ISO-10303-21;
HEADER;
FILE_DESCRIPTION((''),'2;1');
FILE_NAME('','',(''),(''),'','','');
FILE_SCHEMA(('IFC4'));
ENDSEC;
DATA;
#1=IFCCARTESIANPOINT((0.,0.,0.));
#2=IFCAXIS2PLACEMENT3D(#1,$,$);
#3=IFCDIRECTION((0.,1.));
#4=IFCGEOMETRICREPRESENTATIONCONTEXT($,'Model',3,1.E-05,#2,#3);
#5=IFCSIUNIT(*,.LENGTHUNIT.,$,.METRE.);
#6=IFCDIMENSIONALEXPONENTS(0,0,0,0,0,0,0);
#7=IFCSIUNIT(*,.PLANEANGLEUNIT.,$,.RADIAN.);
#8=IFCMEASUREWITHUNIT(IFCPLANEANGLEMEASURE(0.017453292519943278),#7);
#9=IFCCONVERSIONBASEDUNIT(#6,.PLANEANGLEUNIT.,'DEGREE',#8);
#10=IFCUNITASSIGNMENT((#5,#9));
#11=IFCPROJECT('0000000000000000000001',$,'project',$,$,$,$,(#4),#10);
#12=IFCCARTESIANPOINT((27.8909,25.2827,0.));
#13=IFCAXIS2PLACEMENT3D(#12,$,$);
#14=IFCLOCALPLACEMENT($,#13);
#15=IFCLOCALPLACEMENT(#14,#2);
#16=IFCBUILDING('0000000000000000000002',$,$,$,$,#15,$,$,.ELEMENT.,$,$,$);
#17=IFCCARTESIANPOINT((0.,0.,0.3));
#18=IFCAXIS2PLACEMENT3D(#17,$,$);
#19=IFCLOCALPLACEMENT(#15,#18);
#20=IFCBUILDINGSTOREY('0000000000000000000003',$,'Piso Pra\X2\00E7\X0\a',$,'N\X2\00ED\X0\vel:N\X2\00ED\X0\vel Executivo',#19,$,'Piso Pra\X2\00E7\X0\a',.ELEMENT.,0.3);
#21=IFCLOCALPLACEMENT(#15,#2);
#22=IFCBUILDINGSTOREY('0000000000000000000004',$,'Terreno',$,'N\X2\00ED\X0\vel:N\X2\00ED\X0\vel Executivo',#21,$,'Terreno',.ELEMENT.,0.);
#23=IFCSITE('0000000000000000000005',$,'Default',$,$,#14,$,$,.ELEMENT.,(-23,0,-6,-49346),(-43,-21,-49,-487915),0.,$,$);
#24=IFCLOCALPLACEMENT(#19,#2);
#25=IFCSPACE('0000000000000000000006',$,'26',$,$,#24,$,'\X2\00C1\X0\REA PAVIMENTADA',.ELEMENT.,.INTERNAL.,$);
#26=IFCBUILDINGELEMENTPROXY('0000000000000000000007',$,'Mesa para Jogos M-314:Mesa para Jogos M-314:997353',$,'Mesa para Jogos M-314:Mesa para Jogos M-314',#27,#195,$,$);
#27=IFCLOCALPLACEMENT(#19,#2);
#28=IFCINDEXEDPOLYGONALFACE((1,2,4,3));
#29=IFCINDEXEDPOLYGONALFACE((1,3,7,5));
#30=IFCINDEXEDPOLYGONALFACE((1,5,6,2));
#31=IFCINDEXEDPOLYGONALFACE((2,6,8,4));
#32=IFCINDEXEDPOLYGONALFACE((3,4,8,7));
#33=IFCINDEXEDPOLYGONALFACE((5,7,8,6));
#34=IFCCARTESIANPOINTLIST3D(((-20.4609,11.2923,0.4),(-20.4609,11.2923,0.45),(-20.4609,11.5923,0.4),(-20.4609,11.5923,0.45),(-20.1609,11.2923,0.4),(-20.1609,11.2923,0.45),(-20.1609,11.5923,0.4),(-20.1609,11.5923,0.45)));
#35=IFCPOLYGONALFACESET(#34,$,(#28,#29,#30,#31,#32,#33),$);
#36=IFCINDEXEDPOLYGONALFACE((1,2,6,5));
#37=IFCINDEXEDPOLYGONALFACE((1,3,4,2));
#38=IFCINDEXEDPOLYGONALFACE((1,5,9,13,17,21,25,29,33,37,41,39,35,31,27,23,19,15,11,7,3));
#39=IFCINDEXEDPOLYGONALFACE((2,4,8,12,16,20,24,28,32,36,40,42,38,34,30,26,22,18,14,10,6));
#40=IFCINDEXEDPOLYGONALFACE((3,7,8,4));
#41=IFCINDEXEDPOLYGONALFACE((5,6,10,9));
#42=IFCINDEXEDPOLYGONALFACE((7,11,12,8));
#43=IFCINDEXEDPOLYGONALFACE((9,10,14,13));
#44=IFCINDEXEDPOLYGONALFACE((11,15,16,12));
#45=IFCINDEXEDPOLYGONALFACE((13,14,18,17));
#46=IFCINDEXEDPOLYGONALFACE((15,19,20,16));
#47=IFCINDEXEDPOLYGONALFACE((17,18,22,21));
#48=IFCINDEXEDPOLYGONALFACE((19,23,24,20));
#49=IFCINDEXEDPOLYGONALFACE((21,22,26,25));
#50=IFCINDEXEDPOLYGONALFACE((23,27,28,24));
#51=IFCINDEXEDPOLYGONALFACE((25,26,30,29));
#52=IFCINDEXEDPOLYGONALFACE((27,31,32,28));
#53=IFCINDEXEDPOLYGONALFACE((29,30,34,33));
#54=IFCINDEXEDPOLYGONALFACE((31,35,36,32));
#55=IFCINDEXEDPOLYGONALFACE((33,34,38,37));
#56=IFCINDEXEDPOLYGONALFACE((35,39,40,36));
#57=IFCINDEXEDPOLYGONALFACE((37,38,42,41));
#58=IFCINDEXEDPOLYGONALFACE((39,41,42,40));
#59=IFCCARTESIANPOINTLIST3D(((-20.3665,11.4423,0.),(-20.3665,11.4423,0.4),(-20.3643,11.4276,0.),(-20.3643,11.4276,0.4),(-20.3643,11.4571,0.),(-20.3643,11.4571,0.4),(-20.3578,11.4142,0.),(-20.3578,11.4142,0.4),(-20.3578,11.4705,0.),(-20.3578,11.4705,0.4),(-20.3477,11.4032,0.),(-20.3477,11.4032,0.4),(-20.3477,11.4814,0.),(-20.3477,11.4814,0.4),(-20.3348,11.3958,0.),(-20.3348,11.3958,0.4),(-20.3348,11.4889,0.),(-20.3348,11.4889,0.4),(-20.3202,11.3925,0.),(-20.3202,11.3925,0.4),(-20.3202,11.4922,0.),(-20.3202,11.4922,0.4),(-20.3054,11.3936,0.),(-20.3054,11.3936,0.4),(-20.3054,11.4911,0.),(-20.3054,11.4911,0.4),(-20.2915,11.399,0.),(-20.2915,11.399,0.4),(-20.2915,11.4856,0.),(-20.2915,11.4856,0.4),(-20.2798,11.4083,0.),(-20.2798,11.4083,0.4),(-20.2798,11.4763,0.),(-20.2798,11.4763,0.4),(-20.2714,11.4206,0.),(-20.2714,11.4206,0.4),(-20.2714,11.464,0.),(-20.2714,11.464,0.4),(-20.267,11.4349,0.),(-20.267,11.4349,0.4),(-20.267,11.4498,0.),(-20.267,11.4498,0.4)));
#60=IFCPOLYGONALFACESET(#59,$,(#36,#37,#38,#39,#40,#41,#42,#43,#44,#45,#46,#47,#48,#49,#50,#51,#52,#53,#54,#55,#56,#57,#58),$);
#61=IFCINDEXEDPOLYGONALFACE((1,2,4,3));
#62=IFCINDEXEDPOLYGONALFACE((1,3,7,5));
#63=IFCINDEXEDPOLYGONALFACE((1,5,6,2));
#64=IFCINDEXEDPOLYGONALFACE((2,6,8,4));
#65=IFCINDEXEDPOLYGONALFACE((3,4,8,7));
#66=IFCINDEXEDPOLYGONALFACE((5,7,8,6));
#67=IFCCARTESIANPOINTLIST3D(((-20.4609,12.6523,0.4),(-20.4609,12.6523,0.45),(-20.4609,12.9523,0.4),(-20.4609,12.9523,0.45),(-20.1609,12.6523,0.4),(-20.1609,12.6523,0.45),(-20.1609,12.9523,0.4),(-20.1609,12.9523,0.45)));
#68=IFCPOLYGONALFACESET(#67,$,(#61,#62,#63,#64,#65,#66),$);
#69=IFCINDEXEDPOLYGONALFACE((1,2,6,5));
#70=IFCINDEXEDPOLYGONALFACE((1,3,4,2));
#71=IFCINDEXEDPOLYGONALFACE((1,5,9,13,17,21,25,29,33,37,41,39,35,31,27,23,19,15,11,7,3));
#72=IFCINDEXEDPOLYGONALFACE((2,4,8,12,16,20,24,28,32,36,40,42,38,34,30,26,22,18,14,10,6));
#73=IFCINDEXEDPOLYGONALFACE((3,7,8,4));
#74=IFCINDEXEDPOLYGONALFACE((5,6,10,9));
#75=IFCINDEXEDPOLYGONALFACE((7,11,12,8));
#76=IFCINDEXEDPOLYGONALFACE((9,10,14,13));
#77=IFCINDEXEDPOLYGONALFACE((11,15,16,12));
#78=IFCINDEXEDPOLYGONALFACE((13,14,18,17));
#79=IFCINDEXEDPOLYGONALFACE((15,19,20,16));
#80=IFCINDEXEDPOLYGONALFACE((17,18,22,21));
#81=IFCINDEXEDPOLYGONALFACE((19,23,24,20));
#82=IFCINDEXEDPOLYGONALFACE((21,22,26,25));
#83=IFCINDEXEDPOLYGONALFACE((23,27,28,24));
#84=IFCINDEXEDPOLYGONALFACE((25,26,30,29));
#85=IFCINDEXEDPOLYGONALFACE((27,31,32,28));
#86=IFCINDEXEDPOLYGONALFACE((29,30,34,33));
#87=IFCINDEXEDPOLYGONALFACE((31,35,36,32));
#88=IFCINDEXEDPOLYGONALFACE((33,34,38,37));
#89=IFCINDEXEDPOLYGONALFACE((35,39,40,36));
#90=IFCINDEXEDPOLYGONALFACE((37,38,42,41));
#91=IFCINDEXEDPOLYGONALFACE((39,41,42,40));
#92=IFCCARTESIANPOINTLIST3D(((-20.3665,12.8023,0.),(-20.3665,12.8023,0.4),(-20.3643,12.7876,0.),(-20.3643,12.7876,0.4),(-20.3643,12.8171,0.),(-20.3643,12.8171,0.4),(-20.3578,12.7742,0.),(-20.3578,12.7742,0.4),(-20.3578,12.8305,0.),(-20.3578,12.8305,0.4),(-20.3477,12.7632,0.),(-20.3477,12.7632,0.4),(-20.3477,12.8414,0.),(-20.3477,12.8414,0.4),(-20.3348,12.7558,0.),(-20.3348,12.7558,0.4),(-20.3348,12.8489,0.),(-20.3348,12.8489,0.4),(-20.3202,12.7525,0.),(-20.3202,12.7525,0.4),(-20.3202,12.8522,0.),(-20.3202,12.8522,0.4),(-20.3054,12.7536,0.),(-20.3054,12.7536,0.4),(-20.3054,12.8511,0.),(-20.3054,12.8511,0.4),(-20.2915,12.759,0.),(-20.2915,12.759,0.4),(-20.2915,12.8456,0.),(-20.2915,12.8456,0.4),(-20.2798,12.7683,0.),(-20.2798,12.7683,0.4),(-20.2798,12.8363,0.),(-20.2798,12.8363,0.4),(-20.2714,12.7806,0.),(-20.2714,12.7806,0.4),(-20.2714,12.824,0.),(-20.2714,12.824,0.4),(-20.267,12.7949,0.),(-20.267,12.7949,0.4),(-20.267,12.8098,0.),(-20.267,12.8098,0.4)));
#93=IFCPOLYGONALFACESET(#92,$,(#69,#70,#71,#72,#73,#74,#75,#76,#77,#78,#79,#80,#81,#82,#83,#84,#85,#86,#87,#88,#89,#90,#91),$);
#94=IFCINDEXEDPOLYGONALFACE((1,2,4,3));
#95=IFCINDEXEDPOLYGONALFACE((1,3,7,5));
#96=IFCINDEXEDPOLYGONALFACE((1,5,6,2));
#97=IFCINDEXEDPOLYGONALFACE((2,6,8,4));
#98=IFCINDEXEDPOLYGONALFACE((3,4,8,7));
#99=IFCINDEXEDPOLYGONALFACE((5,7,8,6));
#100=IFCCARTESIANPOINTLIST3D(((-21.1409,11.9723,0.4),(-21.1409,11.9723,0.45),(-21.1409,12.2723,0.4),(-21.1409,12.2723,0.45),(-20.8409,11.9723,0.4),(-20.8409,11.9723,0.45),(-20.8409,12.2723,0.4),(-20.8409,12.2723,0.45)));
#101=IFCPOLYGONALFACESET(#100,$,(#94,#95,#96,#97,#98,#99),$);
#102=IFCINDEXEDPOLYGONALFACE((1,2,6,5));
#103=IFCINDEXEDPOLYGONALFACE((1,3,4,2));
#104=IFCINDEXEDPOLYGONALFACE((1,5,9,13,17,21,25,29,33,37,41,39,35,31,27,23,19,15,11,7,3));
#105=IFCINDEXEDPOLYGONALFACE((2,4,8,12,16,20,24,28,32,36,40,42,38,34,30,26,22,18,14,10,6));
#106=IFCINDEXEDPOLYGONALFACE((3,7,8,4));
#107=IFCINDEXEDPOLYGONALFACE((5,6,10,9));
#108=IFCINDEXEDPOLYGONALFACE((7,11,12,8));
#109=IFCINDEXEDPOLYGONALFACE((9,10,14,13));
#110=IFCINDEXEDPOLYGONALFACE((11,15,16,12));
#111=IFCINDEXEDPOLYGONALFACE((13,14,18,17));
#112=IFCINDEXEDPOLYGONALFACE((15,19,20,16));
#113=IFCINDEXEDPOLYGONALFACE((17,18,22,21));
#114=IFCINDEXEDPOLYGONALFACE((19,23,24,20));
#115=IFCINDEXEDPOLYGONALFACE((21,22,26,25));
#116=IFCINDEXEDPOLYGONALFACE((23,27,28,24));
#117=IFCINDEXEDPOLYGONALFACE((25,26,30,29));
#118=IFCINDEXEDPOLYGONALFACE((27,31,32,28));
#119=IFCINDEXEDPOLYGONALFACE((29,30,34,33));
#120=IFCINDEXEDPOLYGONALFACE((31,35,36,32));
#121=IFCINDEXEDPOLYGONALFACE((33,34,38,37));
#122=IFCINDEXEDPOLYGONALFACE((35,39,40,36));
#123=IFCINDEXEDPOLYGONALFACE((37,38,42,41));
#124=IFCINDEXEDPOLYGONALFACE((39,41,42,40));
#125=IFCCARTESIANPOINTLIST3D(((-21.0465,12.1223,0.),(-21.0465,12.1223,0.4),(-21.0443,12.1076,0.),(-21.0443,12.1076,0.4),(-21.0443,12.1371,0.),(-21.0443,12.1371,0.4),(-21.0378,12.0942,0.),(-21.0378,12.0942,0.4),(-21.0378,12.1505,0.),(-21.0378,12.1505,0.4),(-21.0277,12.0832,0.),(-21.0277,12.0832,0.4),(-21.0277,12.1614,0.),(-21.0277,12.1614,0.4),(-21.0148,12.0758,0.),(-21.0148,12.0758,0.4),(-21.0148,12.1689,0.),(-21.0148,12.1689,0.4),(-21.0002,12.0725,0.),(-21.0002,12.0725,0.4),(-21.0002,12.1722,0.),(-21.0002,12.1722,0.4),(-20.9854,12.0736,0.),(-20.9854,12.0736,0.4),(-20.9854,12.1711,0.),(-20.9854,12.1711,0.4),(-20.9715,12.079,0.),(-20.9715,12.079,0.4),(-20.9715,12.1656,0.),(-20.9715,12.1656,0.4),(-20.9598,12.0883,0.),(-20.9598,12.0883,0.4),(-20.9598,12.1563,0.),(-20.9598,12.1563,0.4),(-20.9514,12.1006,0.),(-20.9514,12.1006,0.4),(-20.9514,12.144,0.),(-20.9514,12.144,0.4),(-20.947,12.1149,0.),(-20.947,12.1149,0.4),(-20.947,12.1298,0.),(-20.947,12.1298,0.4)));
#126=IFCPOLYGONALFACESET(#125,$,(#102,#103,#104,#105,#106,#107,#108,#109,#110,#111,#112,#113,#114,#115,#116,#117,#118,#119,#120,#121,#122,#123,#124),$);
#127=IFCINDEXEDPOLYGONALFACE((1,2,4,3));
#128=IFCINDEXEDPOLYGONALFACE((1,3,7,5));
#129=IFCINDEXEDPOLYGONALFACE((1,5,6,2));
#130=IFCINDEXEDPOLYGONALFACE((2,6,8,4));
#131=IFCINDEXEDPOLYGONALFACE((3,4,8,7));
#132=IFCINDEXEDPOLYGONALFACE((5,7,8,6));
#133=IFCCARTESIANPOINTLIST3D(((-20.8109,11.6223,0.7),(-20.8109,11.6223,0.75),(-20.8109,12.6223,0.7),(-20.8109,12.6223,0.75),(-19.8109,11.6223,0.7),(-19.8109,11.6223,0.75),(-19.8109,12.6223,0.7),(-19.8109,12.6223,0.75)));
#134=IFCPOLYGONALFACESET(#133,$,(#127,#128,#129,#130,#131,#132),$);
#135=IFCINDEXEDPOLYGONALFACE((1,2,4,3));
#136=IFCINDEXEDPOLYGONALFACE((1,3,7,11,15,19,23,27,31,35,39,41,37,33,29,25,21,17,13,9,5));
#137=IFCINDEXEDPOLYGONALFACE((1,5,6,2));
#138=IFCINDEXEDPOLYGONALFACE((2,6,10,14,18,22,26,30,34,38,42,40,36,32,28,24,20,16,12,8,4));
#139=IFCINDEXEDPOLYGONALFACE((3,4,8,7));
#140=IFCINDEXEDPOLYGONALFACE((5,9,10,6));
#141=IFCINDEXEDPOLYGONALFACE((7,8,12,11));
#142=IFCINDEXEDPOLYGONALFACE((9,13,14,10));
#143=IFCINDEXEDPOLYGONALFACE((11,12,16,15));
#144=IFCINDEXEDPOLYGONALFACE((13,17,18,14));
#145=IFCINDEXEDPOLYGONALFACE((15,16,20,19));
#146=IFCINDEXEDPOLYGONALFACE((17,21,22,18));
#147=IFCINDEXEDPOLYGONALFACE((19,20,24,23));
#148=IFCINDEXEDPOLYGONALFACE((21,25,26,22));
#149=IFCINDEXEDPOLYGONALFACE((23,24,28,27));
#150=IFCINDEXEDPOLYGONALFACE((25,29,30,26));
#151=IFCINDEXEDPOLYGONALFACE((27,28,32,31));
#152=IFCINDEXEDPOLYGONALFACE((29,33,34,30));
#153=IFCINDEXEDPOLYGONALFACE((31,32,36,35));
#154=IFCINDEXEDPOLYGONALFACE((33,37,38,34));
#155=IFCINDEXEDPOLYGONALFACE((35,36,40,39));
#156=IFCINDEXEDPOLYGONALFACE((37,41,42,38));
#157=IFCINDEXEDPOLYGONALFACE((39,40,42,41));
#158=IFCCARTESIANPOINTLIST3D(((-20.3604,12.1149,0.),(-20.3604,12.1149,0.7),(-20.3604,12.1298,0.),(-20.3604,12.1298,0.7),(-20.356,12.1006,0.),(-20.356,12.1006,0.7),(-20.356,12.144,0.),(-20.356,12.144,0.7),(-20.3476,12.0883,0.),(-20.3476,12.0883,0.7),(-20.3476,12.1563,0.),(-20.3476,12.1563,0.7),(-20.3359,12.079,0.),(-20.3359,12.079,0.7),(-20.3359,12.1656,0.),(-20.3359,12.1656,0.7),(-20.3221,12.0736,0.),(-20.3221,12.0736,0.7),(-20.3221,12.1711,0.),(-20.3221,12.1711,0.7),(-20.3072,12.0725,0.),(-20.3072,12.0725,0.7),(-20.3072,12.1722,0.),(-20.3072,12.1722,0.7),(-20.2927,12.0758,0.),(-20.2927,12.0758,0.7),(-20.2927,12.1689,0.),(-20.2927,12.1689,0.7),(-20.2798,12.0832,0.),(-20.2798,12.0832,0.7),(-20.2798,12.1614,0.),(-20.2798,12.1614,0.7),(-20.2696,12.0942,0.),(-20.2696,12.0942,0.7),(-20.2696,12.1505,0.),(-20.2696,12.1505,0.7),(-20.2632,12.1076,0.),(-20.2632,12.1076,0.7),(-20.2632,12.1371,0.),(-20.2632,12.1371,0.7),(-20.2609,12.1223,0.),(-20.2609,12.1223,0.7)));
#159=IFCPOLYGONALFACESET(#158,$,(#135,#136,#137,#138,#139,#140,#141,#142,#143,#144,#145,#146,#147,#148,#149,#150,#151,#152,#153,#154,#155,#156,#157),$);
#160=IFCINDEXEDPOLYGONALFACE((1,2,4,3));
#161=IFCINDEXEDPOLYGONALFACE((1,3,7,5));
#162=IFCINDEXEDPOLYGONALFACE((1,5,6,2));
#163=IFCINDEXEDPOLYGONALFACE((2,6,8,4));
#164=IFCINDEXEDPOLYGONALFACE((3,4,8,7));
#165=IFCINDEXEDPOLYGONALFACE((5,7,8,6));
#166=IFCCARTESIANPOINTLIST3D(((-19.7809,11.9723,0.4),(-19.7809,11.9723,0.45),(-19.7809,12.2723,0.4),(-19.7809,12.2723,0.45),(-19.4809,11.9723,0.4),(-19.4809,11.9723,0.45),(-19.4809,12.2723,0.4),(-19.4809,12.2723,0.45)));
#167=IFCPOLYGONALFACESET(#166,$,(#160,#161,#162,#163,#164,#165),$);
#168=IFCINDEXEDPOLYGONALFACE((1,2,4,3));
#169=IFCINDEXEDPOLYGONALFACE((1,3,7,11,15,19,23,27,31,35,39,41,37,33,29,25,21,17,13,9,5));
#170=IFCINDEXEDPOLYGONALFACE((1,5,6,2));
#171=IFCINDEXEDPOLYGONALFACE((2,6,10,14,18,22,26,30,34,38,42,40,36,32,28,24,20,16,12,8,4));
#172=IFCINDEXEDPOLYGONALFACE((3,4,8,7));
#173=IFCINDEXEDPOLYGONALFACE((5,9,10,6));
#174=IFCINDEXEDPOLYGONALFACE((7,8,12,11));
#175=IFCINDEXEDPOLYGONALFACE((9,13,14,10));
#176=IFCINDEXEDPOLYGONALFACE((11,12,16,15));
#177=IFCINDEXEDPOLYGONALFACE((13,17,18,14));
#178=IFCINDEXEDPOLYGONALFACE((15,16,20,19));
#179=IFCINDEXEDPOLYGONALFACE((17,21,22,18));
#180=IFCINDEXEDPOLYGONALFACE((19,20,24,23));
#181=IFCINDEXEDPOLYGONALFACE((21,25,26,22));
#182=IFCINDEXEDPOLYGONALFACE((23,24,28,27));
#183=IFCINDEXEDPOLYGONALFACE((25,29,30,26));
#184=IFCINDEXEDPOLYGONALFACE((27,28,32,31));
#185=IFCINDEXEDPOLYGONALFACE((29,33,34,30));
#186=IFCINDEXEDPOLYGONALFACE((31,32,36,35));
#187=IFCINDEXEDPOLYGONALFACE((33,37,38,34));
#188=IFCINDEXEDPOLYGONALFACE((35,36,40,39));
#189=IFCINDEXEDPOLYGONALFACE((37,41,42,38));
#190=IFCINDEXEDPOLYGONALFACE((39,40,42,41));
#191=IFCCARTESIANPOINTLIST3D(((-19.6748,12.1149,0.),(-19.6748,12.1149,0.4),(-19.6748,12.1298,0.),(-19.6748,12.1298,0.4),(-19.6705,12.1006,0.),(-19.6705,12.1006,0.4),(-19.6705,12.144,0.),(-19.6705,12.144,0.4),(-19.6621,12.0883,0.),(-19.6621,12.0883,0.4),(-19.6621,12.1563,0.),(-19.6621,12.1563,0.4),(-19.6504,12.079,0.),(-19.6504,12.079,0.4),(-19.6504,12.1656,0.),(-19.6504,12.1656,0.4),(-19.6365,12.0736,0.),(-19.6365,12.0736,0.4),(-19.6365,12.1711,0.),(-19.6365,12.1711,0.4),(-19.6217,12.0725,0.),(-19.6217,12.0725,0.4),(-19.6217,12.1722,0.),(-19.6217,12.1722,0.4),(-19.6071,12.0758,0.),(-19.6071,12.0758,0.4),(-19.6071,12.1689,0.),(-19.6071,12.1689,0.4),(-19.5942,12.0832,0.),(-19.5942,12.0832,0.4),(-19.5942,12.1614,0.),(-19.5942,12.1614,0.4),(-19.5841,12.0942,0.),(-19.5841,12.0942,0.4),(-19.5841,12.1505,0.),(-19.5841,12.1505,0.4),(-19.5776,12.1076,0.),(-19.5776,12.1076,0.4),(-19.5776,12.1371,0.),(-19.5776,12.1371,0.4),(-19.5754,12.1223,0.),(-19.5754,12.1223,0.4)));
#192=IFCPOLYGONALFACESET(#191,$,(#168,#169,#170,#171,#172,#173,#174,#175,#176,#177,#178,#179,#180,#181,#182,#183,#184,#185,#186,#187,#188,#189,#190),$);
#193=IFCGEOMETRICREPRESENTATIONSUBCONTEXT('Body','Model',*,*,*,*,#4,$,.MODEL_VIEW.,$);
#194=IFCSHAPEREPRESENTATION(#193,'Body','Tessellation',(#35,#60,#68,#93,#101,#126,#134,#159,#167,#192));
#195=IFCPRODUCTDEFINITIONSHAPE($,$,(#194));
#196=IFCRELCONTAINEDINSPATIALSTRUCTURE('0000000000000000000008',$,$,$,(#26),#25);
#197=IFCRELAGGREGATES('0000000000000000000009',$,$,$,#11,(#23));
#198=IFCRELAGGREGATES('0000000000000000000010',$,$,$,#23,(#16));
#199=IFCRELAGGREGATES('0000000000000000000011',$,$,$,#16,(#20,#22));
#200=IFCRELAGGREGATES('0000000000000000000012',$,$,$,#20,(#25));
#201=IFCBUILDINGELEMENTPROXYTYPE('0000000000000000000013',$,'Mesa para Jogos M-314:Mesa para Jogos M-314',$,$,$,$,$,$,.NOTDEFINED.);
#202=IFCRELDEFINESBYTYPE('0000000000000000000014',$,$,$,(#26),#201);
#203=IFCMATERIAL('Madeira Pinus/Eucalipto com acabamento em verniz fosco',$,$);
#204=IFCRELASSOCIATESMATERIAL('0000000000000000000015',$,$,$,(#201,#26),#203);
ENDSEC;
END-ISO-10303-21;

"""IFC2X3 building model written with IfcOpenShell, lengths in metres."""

from ifc_helpers import new_model, entity, si_unit, converted_unit, direction, frame, frame_2d, origin, place, context, subcontext, project, spatial, rectangle, circle, extrude, source, transform, mapped, material, type_object, type_shapes, element, save


model = new_model("IFC2X3")

# Units and contexts
model_context = context("Model", 3, precision=1e-05, world=origin(), true_north=direction((0.0, 1.0)))
body_context = subcontext(model_context, "Body", "Model", "MODEL_VIEW")
ifc_project = project(units=[si_unit("LENGTHUNIT", "METRE"), converted_unit("PLANEANGLEUNIT", "DEGREE", entity("IfcPlaneAngleMeasure", 0.017453292519943278), si_unit("PLANEANGLEUNIT", "RADIAN"), dimensions=[0, 0, 0, 0, 0, 0, 0])], contexts=[model_context])

# Site, building, storey
site_placement = place(None, frame((27.8909, 25.2827, 0.0)))
site = spatial("IfcSite", under=ifc_project, at=site_placement, Name="Default", CompositionType="ELEMENT", RefLatitude=(-23, 0, -6, -49346), RefLongitude=(-43, -21, -49, -487915), RefElevation=0.0)
building_placement = place(site_placement, origin())
building = spatial("IfcBuilding", under=site, at=building_placement, CompositionType="ELEMENT")
storey_1_placement = place(building_placement, frame((0.0, 0.0, 0.3)))
storey_1 = spatial("IfcBuildingStorey", under=building, at=storey_1_placement, Name="Piso Praça", ObjectType="Nível:Nível Executivo", LongName="Piso Praça", CompositionType="ELEMENT", Elevation=0.3)

# Shared definitions
ifc_material_1 = material(Name="Madeira Pinus/Eucalipto com acabamento em verniz fosco")

# Shared definitions
space_1_placement = place(storey_1_placement, origin())
space_1 = spatial("IfcSpace", under=storey_1, at=space_1_placement, Name="26", LongName="ÁREA PAVIMENTADA", CompositionType="ELEMENT", InteriorOrExteriorSpace="INTERNAL")

# Shared definitions
building_element_proxy_type_1 = type_object("IfcBuildingElementProxyType", Name="Mesa para Jogos M-314:Mesa para Jogos M-314", PredefinedType="NOTDEFINED", material=ifc_material_1)
shared_shape_1 = source(origin(), body_context, "Body", "SweptSolid", [
    extrude(rectangle(XDim=0.3, YDim=0.3, at=frame_2d((0.0, 0.0), x_axis=(1.0, 0.0))), frame((0.0, -0.68, 0.4)), (0.0, 0.0, 1.0), 0.05),
    extrude(circle(Radius=0.05, at=frame_2d((0.0, 0.0), x_axis=(1.0, 0.0))), frame((-0.0055, -0.68, 0.0), z_axis=(0.0, 0.0, 1.0), x_axis=(-1.0, 0.0, 0.0)), (0.0, 0.0, 1.0), 0.4),
    extrude(rectangle(XDim=0.3, YDim=0.3, at=frame_2d((0.0, 0.0), x_axis=(1.0, 0.0))), frame((0.0, 0.68, 0.4), z_axis=(0.0, 0.0, 1.0), x_axis=(0.0, -1.0, 0.0)), (0.0, 0.0, 1.0), 0.05),
    extrude(circle(Radius=0.05, at=frame_2d((0.0, 0.0), x_axis=(1.0, 0.0))), frame((-0.0055, 0.68, 0.0), z_axis=(0.0, 0.0, 1.0), x_axis=(-1.0, 0.0, 0.0)), (0.0, 0.0, 1.0), 0.4),
    extrude(rectangle(XDim=0.3, YDim=0.3, at=frame_2d((0.0, 0.0), x_axis=(1.0, 0.0))), frame((-0.68, 0.0, 0.4), z_axis=(0.0, 0.0, 1.0), x_axis=(0.0, -1.0, 0.0)), (0.0, 0.0, 1.0), 0.05),
    extrude(circle(Radius=0.05, at=frame_2d((0.0, 0.0), x_axis=(1.0, 0.0))), frame((-0.6855, 0.0, 0.0), z_axis=(0.0, 0.0, 1.0), x_axis=(-1.0, 0.0, 0.0)), (0.0, 0.0, 1.0), 0.4),
    extrude(rectangle(XDim=1.0, YDim=1.0, at=frame_2d((0.0, 0.0), x_axis=(1.0, 0.0))), frame((0.0, 0.0, 0.7), z_axis=(0.0, 0.0, 1.0), x_axis=(-1.0, 0.0, 0.0)), (0.0, 0.0, 1.0), 0.05),
    extrude(circle(Radius=0.05, at=frame_2d((0.0, 0.0), x_axis=(1.0, 0.0))), origin(), (0.0, 0.0, 1.0), 0.7),
    extrude(rectangle(XDim=0.3, YDim=0.3, at=frame_2d((0.0, 0.0), x_axis=(1.0, 0.0))), frame((0.68, 0.0, 0.4), z_axis=(0.0, 0.0, 1.0), x_axis=(-1.0, 0.0, 0.0)), (0.0, 0.0, 1.0), 0.05),
    extrude(circle(Radius=0.05, at=frame_2d((0.0, 0.0), x_axis=(1.0, 0.0))), frame((0.6855, 0.0, 0.0)), (0.0, 0.0, 1.0), 0.4),
])
type_shapes(building_element_proxy_type_1, [shared_shape_1])

# Shared definitions
storey_2_placement = place(building_placement, origin())
storey_2 = spatial("IfcBuildingStorey", under=building, at=storey_2_placement, Name="Terreno", ObjectType="Nível:Nível Executivo", LongName="Terreno", CompositionType="ELEMENT", Elevation=0.0)

# Building element proxy
proxy_1_placement = place(space_1_placement, frame((-20.3109, 12.1223, 0.0)))
element("IfcBuildingElementProxy", 1, at=proxy_1_placement, inside=space_1, type_object=building_element_proxy_type_1, material=ifc_material_1, Name="Mesa para Jogos M-314:Mesa para Jogos M-314:997353", ObjectType="Mesa para Jogos M-314:Mesa para Jogos M-314", context=body_context, shape_type="MappedRepresentation", body=[
    mapped(shared_shape_1, transform((0.0, 0.0, 0.0), scale=1.0)),
])

save(model, "model.ifc")
